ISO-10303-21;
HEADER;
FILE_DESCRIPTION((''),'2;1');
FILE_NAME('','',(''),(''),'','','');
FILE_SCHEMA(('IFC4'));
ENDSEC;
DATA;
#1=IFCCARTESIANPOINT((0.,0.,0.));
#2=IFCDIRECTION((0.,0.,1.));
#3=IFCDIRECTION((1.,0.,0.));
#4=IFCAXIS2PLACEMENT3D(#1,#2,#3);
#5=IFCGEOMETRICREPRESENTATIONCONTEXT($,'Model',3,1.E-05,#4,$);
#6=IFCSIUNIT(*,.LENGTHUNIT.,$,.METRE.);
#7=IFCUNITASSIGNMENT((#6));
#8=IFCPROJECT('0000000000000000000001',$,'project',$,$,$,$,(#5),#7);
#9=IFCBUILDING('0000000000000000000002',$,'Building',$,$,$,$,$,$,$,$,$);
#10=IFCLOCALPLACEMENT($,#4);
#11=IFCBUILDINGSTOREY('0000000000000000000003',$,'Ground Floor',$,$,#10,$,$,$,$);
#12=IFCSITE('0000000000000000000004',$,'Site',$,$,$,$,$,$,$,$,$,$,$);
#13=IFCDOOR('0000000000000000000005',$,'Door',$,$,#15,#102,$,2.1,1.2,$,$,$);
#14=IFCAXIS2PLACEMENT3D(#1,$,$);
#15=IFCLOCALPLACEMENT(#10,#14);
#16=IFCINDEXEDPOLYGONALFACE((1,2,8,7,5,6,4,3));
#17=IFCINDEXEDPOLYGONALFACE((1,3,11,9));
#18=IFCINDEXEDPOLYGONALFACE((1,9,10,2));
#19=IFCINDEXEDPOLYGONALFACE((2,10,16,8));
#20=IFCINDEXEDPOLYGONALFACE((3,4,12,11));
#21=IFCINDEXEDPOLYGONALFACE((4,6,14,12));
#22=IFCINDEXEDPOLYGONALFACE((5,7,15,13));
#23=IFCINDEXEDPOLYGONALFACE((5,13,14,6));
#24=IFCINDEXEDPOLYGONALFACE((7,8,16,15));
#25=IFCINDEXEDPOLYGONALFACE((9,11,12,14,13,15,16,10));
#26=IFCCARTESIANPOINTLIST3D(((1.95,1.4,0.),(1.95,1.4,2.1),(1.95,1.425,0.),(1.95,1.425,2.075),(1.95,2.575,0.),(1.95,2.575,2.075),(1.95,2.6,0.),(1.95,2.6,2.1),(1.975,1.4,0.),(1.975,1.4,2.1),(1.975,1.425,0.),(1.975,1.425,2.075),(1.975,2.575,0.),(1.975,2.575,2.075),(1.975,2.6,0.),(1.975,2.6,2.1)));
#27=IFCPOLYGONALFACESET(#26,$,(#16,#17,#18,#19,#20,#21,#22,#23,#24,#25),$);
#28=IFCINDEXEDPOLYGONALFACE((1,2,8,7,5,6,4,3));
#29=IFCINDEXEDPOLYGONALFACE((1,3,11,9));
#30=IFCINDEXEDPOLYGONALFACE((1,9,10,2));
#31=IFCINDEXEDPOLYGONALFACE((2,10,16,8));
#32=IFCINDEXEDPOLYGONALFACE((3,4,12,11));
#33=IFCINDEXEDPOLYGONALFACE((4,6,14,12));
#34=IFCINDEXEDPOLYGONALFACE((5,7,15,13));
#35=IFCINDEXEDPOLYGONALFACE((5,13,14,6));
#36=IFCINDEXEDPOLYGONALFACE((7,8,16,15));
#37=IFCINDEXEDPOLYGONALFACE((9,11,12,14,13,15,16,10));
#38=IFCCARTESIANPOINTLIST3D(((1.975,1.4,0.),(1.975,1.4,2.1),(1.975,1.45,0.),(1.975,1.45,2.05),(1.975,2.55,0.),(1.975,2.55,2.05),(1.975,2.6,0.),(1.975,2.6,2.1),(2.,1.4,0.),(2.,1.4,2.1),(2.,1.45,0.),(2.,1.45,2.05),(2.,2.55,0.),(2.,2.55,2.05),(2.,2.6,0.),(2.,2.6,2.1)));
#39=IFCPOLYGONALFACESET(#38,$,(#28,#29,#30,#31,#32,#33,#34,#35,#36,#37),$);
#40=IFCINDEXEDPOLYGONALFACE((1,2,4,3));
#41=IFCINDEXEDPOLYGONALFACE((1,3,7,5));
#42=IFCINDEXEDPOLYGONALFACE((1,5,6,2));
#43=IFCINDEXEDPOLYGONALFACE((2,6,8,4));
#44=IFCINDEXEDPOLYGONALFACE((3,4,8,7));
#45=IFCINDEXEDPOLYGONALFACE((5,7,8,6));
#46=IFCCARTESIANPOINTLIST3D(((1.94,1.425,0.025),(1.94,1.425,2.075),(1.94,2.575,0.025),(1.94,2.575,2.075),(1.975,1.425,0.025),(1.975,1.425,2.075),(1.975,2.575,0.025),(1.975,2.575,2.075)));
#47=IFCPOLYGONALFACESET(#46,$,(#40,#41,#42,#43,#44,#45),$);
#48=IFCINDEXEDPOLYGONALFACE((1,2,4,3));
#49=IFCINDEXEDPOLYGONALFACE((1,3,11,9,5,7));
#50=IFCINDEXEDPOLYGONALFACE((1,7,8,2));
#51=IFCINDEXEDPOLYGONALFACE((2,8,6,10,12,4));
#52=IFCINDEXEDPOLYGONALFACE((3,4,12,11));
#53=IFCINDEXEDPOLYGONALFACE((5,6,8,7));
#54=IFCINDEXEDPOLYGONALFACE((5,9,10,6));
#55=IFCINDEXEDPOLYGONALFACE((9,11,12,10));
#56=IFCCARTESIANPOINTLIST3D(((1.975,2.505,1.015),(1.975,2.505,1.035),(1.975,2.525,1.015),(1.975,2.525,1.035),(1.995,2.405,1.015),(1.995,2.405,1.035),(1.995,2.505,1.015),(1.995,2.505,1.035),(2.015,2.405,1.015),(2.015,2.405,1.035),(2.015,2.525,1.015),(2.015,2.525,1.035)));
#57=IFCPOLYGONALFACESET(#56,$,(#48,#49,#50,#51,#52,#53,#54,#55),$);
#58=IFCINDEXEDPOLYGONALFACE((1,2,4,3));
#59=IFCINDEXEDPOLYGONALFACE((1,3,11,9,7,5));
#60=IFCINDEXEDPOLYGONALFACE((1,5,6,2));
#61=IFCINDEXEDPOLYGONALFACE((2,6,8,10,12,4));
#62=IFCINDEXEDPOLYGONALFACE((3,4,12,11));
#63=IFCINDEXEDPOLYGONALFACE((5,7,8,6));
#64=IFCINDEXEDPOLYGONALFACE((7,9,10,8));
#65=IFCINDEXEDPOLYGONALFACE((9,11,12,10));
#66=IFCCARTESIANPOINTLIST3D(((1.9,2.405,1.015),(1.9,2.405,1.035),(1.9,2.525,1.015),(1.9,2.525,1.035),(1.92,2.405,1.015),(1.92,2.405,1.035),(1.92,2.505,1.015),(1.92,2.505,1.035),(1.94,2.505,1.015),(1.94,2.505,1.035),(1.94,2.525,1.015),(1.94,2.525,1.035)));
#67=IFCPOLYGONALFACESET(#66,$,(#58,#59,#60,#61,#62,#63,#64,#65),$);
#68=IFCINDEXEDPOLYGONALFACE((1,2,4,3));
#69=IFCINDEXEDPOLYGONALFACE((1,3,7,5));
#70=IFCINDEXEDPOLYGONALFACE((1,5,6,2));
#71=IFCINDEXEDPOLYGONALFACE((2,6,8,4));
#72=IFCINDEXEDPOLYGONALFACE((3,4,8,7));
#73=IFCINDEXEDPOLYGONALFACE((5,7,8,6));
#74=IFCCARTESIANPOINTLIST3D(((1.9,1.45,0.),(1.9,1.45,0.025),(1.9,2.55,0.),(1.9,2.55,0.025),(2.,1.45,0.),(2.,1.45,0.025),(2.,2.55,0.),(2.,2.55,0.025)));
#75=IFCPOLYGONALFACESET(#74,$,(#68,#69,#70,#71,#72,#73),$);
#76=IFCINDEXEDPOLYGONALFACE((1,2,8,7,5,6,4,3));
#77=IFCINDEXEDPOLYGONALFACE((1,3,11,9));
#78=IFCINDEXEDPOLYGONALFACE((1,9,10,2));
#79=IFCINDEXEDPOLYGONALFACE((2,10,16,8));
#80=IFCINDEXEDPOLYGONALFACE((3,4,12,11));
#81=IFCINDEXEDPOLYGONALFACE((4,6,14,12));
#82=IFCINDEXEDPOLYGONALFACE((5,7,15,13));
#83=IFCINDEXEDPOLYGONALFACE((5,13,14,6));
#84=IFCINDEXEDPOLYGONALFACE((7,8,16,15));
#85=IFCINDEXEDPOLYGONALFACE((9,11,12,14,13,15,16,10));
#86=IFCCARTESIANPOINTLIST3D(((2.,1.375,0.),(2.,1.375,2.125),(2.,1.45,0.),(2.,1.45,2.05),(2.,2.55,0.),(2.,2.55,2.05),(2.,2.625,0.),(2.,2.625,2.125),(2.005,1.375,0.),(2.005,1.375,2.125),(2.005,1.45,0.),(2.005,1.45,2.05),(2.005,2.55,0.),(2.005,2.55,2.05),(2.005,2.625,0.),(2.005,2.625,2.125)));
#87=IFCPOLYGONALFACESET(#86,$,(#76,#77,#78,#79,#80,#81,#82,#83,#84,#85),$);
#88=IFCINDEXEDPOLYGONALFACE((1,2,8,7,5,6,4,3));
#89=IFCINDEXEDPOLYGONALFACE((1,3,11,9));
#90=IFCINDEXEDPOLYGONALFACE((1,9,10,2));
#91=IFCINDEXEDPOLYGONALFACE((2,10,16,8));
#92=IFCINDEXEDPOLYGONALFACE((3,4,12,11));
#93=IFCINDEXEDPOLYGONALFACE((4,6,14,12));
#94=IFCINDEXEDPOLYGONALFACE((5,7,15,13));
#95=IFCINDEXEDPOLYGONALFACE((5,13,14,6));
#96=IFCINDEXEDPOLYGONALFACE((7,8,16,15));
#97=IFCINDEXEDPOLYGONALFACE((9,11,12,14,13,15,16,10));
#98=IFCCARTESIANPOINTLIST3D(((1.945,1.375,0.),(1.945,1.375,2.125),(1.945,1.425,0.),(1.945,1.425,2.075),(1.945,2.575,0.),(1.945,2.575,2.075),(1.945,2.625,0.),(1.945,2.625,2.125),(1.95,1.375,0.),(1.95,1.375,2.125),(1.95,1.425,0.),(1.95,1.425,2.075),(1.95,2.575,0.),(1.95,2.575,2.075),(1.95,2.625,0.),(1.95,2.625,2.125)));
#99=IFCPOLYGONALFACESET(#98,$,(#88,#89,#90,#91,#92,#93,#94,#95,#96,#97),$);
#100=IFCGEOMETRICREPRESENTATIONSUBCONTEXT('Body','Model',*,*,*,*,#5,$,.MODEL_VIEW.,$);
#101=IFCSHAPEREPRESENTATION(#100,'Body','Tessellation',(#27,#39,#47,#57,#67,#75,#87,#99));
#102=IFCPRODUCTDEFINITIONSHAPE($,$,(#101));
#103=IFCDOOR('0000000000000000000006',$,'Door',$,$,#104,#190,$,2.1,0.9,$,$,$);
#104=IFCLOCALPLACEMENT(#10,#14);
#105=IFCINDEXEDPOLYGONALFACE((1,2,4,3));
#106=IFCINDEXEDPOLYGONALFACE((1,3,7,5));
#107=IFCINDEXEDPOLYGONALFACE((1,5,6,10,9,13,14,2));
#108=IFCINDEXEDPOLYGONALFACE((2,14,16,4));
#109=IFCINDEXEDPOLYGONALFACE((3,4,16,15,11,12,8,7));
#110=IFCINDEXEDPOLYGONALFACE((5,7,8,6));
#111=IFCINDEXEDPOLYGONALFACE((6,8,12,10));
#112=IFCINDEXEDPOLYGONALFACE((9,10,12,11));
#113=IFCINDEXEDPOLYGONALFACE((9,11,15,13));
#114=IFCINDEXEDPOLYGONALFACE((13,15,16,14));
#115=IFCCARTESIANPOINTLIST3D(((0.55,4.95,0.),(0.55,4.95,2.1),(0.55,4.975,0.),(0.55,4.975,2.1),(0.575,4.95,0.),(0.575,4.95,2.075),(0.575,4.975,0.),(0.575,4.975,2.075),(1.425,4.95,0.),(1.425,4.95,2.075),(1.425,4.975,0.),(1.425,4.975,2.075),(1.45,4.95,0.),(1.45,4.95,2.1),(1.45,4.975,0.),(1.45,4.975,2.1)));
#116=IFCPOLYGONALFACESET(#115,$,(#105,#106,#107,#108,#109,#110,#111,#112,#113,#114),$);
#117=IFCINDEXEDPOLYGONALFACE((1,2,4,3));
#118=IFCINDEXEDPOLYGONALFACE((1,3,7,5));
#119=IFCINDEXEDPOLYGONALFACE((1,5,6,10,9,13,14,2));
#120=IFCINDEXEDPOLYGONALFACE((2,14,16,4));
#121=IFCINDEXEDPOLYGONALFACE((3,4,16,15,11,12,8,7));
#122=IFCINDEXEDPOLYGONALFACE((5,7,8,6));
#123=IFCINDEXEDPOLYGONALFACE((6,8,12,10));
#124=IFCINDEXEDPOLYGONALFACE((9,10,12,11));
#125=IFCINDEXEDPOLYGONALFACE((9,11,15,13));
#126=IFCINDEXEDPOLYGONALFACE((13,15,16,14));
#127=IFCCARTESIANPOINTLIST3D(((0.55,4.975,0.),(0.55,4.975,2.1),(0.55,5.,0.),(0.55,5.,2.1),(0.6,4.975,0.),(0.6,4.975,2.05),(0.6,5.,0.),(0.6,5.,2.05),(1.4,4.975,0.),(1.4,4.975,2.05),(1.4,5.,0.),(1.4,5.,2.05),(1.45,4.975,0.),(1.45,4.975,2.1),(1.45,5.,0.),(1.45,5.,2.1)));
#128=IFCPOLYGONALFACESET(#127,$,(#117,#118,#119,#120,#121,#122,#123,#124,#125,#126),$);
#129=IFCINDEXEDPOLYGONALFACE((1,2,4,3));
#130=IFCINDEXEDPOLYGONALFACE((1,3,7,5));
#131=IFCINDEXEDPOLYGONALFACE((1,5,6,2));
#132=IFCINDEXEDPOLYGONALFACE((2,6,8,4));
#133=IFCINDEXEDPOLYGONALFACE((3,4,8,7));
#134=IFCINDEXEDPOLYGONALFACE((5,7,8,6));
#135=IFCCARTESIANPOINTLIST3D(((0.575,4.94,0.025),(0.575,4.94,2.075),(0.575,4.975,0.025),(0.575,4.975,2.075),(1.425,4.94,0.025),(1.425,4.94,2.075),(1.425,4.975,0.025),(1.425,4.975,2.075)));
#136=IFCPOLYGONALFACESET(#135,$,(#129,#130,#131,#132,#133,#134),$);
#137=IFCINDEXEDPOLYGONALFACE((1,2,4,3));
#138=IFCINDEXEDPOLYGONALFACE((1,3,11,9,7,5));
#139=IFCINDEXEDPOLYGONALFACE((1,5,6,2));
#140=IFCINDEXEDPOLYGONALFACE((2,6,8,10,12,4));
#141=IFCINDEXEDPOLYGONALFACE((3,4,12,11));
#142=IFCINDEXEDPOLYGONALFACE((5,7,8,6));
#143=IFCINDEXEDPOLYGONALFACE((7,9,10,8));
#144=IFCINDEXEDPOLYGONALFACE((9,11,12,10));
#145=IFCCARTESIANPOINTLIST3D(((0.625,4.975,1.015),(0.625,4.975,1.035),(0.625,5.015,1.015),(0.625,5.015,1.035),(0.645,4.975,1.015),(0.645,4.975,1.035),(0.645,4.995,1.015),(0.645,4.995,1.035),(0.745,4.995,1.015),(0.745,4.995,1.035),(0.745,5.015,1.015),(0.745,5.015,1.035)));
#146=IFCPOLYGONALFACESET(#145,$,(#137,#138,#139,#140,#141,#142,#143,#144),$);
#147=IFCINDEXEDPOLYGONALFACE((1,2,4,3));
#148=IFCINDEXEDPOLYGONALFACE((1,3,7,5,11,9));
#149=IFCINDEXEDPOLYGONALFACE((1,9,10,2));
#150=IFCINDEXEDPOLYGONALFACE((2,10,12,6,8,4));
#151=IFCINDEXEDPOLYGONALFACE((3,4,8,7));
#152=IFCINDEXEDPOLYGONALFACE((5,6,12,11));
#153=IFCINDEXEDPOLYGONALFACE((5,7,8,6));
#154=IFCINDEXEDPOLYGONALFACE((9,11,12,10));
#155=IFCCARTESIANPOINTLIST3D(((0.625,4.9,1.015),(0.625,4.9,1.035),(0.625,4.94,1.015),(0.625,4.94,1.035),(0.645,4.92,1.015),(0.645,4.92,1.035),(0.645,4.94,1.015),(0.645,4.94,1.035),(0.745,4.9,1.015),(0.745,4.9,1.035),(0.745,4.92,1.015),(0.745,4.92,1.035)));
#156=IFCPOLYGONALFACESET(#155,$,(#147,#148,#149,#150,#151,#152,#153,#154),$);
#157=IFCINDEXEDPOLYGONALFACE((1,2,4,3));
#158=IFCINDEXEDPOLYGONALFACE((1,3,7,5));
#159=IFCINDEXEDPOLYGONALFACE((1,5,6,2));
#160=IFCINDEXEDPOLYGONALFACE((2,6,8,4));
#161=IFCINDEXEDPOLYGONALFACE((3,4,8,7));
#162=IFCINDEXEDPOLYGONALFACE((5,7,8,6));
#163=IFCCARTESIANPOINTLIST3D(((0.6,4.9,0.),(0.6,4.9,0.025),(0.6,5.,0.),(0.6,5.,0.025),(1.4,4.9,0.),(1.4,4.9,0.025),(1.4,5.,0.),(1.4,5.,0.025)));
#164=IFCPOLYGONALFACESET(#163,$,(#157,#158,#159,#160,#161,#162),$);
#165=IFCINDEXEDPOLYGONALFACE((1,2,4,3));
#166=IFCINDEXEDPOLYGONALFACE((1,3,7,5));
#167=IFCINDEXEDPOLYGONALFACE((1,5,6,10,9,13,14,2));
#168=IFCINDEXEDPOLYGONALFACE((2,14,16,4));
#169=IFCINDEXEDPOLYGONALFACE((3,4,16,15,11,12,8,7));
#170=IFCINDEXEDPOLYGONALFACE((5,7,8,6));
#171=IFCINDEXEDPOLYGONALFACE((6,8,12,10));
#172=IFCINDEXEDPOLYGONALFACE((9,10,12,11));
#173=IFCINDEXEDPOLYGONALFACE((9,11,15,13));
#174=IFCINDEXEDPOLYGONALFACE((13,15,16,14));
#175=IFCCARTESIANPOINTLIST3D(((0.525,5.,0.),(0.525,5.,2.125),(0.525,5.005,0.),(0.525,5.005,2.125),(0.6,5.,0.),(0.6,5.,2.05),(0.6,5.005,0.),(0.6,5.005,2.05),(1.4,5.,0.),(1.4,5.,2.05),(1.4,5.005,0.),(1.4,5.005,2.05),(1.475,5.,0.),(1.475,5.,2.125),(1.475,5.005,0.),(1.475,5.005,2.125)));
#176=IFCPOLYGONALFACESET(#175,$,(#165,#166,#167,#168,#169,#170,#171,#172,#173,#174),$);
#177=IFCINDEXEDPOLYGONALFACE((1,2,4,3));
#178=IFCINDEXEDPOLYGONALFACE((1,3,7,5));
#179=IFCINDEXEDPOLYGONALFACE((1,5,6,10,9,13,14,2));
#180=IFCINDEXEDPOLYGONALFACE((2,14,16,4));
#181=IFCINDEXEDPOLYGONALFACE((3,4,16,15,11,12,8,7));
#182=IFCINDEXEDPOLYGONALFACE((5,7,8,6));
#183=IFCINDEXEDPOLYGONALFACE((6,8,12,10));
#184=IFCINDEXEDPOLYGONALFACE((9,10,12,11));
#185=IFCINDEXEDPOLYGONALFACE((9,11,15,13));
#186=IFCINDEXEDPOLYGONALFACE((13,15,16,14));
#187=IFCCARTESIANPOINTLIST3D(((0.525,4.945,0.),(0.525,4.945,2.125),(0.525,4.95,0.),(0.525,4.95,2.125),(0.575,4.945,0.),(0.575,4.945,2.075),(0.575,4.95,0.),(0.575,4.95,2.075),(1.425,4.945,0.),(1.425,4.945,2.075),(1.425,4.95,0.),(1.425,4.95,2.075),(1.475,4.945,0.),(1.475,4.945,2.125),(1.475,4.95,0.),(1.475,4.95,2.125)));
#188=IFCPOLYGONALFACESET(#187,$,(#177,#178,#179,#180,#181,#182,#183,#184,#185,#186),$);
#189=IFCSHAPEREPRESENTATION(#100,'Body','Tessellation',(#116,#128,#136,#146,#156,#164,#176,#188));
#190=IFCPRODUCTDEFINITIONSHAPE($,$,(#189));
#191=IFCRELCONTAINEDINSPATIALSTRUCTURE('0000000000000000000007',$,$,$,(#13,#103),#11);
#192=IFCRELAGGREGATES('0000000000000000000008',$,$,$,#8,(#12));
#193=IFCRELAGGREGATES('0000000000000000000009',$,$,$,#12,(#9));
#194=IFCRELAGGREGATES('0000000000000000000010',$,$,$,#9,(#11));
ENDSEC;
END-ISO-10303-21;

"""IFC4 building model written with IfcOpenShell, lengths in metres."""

from ifc_helpers import new_model, si_unit, frame, origin_with_axes, place, context, subcontext, project, spatial, line, indexed_curve, outline, extrude, element, save


model = new_model("IFC4")

# Units and contexts
model_context = context("Model", 3, precision=1e-05, world=origin_with_axes())
body_context = subcontext(model_context, "Body", "Model", "MODEL_VIEW")
ifc_project = project(units=[si_unit("LENGTHUNIT", "METRE")], contexts=[model_context])

# Site, building, storey
site = spatial("IfcSite", under=ifc_project, Name="Site")
building = spatial("IfcBuilding", under=site, Name="Building")
storey_placement = place(None, origin_with_axes())
storey = spatial("IfcBuildingStorey", under=building, at=storey_placement, Name="Ground Floor")

# Doors
door_1_placement = place(storey_placement, frame((2.0, 1.4, 0.0), z_axis=(0.0, 0.0, 1.0), x_axis=(0.0, 1.0, 0.0)))
element("IfcDoor", 1, at=door_1_placement, inside=storey, Name="Door", OverallHeight=2.1, OverallWidth=1.2, context=body_context, shape_type="SweptSolid", body=[
    extrude(outline(indexed_curve([(0.0, 0.0), (0.0, 2.1), (1.2, 2.1), (1.2, 0.0), (1.175, 0.0), (1.175, 2.075), (0.025, 2.075), (0.025, 0.0)], segments=[line(1, 2, 3, 4, 5, 6, 7, 8, 1)])), frame((0.0, 0.025, 0.0), z_axis=(0.0, -1.0, 0.0), x_axis=(1.0, 0.0, 0.0)), (0.0, 0.0, -1.0), 0.025),
    extrude(outline(indexed_curve([(0.0, 0.0), (0.0, 2.1), (1.2, 2.1), (1.2, 0.0), (1.15, 0.0), (1.15, 2.05), (0.05, 2.05), (0.05, 0.0)], segments=[line(1, 2, 3, 4, 5, 6, 7, 8, 1)])), frame((0.0, 0.0, 0.0), z_axis=(0.0, -1.0, 0.0), x_axis=(1.0, 0.0, 0.0)), (0.0, 0.0, -1.0), 0.025),
    extrude(outline(indexed_curve([(0.0, 0.0), (1.15, 0.0), (1.15, 0.035), (0.0, 0.035)], segments=[line(1, 2, 3, 4, 1)])), frame((0.025, 0.025, 0.025), z_axis=(0.0, 0.0, 1.0), x_axis=(1.0, 0.0, 0.0)), (0.0, 0.0, 1.0), 2.05),
    extrude(outline(indexed_curve([(0.0, 0.0), (0.0, -0.04), (-0.12, -0.04), (-0.12, -0.02), (-0.02, -0.02), (-0.02, 0.0)], segments=[line(1, 2, 3, 4, 5, 6, 1)])), frame((1.125, 0.025, 1.015), z_axis=(0.0, 0.0, 1.0), x_axis=(1.0, 0.0, 0.0)), (0.0, 0.0, 1.0), 0.02),
    extrude(outline(indexed_curve([(0.0, 0.0), (0.0, 0.04), (-0.12, 0.04), (-0.12, 0.02), (-0.02, 0.02), (-0.02, 0.0)], segments=[line(1, 2, 3, 4, 5, 6, 1)])), frame((1.125, 0.06, 1.015), z_axis=(0.0, 0.0, 1.0), x_axis=(1.0, 0.0, 0.0)), (0.0, 0.0, 1.0), 0.02),
    extrude(outline(indexed_curve([(0.0, 0.0), (1.1, 0.0), (1.1, 0.1), (0.0, 0.1)], segments=[line(1, 2, 3, 4, 1)])), frame((0.05, 0.0, 0.0), z_axis=(0.0, 0.0, 1.0), x_axis=(1.0, 0.0, 0.0)), (0.0, 0.0, 1.0), 0.025),
    extrude(outline(indexed_curve([(0.0, 0.0), (0.0, 2.125), (1.25, 2.125), (1.25, 0.0), (1.175, 0.0), (1.175, 2.05), (0.075, 2.05), (0.075, 0.0)], segments=[line(1, 2, 3, 4, 5, 6, 7, 8, 1)])), frame((-0.025, -0.005, 0.0), z_axis=(0.0, -1.0, 0.0), x_axis=(1.0, 0.0, 0.0)), (0.0, 0.0, -1.0), 0.005),
    extrude(outline(indexed_curve([(0.0, 0.0), (0.0, 2.125), (1.25, 2.125), (1.25, 0.0), (1.2, 0.0), (1.2, 2.075), (0.05, 2.075), (0.05, 0.0)], segments=[line(1, 2, 3, 4, 5, 6, 7, 8, 1)])), frame((-0.025, 0.05, 0.0), z_axis=(0.0, -1.0, 0.0), x_axis=(1.0, 0.0, 0.0)), (0.0, 0.0, -1.0), 0.005),
])
door_2_placement = place(storey_placement, frame((1.45, 5.0, 0.0), z_axis=(0.0, 0.0, 1.0), x_axis=(-1.0, 0.0, 0.0)))
element("IfcDoor", 2, at=door_2_placement, inside=storey, Name="Door", OverallHeight=2.1, OverallWidth=0.9, context=body_context, shape_type="SweptSolid", body=[
    extrude(outline(indexed_curve([(0.0, 0.0), (0.0, 2.1), (0.9, 2.1), (0.9, 0.0), (0.875, 0.0), (0.875, 2.075), (0.025, 2.075), (0.025, 0.0)], segments=[line(1, 2, 3, 4, 5, 6, 7, 8, 1)])), frame((0.0, 0.025, 0.0), z_axis=(0.0, -1.0, 0.0), x_axis=(1.0, 0.0, 0.0)), (0.0, 0.0, -1.0), 0.025),
    extrude(outline(indexed_curve([(0.0, 0.0), (0.0, 2.1), (0.9, 2.1), (0.9, 0.0), (0.85, 0.0), (0.85, 2.05), (0.05, 2.05), (0.05, 0.0)], segments=[line(1, 2, 3, 4, 5, 6, 7, 8, 1)])), frame((0.0, 0.0, 0.0), z_axis=(0.0, -1.0, 0.0), x_axis=(1.0, 0.0, 0.0)), (0.0, 0.0, -1.0), 0.025),
    extrude(outline(indexed_curve([(0.0, 0.0), (0.85, 0.0), (0.85, 0.035), (0.0, 0.035)], segments=[line(1, 2, 3, 4, 1)])), frame((0.025, 0.025, 0.025), z_axis=(0.0, 0.0, 1.0), x_axis=(1.0, 0.0, 0.0)), (0.0, 0.0, 1.0), 2.05),
    extrude(outline(indexed_curve([(0.0, 0.0), (0.0, -0.04), (-0.12, -0.04), (-0.12, -0.02), (-0.02, -0.02), (-0.02, 0.0)], segments=[line(1, 2, 3, 4, 5, 6, 1)])), frame((0.825, 0.025, 1.015), z_axis=(0.0, 0.0, 1.0), x_axis=(1.0, 0.0, 0.0)), (0.0, 0.0, 1.0), 0.02),
    extrude(outline(indexed_curve([(0.0, 0.0), (0.0, 0.04), (-0.12, 0.04), (-0.12, 0.02), (-0.02, 0.02), (-0.02, 0.0)], segments=[line(1, 2, 3, 4, 5, 6, 1)])), frame((0.825, 0.06, 1.015), z_axis=(0.0, 0.0, 1.0), x_axis=(1.0, 0.0, 0.0)), (0.0, 0.0, 1.0), 0.02),
    extrude(outline(indexed_curve([(0.0, 0.0), (0.8, 0.0), (0.8, 0.1), (0.0, 0.1)], segments=[line(1, 2, 3, 4, 1)])), frame((0.05, 0.0, 0.0), z_axis=(0.0, 0.0, 1.0), x_axis=(1.0, 0.0, 0.0)), (0.0, 0.0, 1.0), 0.025),
    extrude(outline(indexed_curve([(0.0, 0.0), (0.0, 2.125), (0.95, 2.125), (0.95, 0.0), (0.875, 0.0), (0.875, 2.05), (0.075, 2.05), (0.075, 0.0)], segments=[line(1, 2, 3, 4, 5, 6, 7, 8, 1)])), frame((-0.025, -0.005, 0.0), z_axis=(0.0, -1.0, 0.0), x_axis=(1.0, 0.0, 0.0)), (0.0, 0.0, -1.0), 0.005),
    extrude(outline(indexed_curve([(0.0, 0.0), (0.0, 2.125), (0.95, 2.125), (0.95, 0.0), (0.9, 0.0), (0.9, 2.075), (0.05, 2.075), (0.05, 0.0)], segments=[line(1, 2, 3, 4, 5, 6, 7, 8, 1)])), frame((-0.025, 0.05, 0.0), z_axis=(0.0, -1.0, 0.0), x_axis=(1.0, 0.0, 0.0)), (0.0, 0.0, -1.0), 0.005),
])

save(model, "model.ifc")
